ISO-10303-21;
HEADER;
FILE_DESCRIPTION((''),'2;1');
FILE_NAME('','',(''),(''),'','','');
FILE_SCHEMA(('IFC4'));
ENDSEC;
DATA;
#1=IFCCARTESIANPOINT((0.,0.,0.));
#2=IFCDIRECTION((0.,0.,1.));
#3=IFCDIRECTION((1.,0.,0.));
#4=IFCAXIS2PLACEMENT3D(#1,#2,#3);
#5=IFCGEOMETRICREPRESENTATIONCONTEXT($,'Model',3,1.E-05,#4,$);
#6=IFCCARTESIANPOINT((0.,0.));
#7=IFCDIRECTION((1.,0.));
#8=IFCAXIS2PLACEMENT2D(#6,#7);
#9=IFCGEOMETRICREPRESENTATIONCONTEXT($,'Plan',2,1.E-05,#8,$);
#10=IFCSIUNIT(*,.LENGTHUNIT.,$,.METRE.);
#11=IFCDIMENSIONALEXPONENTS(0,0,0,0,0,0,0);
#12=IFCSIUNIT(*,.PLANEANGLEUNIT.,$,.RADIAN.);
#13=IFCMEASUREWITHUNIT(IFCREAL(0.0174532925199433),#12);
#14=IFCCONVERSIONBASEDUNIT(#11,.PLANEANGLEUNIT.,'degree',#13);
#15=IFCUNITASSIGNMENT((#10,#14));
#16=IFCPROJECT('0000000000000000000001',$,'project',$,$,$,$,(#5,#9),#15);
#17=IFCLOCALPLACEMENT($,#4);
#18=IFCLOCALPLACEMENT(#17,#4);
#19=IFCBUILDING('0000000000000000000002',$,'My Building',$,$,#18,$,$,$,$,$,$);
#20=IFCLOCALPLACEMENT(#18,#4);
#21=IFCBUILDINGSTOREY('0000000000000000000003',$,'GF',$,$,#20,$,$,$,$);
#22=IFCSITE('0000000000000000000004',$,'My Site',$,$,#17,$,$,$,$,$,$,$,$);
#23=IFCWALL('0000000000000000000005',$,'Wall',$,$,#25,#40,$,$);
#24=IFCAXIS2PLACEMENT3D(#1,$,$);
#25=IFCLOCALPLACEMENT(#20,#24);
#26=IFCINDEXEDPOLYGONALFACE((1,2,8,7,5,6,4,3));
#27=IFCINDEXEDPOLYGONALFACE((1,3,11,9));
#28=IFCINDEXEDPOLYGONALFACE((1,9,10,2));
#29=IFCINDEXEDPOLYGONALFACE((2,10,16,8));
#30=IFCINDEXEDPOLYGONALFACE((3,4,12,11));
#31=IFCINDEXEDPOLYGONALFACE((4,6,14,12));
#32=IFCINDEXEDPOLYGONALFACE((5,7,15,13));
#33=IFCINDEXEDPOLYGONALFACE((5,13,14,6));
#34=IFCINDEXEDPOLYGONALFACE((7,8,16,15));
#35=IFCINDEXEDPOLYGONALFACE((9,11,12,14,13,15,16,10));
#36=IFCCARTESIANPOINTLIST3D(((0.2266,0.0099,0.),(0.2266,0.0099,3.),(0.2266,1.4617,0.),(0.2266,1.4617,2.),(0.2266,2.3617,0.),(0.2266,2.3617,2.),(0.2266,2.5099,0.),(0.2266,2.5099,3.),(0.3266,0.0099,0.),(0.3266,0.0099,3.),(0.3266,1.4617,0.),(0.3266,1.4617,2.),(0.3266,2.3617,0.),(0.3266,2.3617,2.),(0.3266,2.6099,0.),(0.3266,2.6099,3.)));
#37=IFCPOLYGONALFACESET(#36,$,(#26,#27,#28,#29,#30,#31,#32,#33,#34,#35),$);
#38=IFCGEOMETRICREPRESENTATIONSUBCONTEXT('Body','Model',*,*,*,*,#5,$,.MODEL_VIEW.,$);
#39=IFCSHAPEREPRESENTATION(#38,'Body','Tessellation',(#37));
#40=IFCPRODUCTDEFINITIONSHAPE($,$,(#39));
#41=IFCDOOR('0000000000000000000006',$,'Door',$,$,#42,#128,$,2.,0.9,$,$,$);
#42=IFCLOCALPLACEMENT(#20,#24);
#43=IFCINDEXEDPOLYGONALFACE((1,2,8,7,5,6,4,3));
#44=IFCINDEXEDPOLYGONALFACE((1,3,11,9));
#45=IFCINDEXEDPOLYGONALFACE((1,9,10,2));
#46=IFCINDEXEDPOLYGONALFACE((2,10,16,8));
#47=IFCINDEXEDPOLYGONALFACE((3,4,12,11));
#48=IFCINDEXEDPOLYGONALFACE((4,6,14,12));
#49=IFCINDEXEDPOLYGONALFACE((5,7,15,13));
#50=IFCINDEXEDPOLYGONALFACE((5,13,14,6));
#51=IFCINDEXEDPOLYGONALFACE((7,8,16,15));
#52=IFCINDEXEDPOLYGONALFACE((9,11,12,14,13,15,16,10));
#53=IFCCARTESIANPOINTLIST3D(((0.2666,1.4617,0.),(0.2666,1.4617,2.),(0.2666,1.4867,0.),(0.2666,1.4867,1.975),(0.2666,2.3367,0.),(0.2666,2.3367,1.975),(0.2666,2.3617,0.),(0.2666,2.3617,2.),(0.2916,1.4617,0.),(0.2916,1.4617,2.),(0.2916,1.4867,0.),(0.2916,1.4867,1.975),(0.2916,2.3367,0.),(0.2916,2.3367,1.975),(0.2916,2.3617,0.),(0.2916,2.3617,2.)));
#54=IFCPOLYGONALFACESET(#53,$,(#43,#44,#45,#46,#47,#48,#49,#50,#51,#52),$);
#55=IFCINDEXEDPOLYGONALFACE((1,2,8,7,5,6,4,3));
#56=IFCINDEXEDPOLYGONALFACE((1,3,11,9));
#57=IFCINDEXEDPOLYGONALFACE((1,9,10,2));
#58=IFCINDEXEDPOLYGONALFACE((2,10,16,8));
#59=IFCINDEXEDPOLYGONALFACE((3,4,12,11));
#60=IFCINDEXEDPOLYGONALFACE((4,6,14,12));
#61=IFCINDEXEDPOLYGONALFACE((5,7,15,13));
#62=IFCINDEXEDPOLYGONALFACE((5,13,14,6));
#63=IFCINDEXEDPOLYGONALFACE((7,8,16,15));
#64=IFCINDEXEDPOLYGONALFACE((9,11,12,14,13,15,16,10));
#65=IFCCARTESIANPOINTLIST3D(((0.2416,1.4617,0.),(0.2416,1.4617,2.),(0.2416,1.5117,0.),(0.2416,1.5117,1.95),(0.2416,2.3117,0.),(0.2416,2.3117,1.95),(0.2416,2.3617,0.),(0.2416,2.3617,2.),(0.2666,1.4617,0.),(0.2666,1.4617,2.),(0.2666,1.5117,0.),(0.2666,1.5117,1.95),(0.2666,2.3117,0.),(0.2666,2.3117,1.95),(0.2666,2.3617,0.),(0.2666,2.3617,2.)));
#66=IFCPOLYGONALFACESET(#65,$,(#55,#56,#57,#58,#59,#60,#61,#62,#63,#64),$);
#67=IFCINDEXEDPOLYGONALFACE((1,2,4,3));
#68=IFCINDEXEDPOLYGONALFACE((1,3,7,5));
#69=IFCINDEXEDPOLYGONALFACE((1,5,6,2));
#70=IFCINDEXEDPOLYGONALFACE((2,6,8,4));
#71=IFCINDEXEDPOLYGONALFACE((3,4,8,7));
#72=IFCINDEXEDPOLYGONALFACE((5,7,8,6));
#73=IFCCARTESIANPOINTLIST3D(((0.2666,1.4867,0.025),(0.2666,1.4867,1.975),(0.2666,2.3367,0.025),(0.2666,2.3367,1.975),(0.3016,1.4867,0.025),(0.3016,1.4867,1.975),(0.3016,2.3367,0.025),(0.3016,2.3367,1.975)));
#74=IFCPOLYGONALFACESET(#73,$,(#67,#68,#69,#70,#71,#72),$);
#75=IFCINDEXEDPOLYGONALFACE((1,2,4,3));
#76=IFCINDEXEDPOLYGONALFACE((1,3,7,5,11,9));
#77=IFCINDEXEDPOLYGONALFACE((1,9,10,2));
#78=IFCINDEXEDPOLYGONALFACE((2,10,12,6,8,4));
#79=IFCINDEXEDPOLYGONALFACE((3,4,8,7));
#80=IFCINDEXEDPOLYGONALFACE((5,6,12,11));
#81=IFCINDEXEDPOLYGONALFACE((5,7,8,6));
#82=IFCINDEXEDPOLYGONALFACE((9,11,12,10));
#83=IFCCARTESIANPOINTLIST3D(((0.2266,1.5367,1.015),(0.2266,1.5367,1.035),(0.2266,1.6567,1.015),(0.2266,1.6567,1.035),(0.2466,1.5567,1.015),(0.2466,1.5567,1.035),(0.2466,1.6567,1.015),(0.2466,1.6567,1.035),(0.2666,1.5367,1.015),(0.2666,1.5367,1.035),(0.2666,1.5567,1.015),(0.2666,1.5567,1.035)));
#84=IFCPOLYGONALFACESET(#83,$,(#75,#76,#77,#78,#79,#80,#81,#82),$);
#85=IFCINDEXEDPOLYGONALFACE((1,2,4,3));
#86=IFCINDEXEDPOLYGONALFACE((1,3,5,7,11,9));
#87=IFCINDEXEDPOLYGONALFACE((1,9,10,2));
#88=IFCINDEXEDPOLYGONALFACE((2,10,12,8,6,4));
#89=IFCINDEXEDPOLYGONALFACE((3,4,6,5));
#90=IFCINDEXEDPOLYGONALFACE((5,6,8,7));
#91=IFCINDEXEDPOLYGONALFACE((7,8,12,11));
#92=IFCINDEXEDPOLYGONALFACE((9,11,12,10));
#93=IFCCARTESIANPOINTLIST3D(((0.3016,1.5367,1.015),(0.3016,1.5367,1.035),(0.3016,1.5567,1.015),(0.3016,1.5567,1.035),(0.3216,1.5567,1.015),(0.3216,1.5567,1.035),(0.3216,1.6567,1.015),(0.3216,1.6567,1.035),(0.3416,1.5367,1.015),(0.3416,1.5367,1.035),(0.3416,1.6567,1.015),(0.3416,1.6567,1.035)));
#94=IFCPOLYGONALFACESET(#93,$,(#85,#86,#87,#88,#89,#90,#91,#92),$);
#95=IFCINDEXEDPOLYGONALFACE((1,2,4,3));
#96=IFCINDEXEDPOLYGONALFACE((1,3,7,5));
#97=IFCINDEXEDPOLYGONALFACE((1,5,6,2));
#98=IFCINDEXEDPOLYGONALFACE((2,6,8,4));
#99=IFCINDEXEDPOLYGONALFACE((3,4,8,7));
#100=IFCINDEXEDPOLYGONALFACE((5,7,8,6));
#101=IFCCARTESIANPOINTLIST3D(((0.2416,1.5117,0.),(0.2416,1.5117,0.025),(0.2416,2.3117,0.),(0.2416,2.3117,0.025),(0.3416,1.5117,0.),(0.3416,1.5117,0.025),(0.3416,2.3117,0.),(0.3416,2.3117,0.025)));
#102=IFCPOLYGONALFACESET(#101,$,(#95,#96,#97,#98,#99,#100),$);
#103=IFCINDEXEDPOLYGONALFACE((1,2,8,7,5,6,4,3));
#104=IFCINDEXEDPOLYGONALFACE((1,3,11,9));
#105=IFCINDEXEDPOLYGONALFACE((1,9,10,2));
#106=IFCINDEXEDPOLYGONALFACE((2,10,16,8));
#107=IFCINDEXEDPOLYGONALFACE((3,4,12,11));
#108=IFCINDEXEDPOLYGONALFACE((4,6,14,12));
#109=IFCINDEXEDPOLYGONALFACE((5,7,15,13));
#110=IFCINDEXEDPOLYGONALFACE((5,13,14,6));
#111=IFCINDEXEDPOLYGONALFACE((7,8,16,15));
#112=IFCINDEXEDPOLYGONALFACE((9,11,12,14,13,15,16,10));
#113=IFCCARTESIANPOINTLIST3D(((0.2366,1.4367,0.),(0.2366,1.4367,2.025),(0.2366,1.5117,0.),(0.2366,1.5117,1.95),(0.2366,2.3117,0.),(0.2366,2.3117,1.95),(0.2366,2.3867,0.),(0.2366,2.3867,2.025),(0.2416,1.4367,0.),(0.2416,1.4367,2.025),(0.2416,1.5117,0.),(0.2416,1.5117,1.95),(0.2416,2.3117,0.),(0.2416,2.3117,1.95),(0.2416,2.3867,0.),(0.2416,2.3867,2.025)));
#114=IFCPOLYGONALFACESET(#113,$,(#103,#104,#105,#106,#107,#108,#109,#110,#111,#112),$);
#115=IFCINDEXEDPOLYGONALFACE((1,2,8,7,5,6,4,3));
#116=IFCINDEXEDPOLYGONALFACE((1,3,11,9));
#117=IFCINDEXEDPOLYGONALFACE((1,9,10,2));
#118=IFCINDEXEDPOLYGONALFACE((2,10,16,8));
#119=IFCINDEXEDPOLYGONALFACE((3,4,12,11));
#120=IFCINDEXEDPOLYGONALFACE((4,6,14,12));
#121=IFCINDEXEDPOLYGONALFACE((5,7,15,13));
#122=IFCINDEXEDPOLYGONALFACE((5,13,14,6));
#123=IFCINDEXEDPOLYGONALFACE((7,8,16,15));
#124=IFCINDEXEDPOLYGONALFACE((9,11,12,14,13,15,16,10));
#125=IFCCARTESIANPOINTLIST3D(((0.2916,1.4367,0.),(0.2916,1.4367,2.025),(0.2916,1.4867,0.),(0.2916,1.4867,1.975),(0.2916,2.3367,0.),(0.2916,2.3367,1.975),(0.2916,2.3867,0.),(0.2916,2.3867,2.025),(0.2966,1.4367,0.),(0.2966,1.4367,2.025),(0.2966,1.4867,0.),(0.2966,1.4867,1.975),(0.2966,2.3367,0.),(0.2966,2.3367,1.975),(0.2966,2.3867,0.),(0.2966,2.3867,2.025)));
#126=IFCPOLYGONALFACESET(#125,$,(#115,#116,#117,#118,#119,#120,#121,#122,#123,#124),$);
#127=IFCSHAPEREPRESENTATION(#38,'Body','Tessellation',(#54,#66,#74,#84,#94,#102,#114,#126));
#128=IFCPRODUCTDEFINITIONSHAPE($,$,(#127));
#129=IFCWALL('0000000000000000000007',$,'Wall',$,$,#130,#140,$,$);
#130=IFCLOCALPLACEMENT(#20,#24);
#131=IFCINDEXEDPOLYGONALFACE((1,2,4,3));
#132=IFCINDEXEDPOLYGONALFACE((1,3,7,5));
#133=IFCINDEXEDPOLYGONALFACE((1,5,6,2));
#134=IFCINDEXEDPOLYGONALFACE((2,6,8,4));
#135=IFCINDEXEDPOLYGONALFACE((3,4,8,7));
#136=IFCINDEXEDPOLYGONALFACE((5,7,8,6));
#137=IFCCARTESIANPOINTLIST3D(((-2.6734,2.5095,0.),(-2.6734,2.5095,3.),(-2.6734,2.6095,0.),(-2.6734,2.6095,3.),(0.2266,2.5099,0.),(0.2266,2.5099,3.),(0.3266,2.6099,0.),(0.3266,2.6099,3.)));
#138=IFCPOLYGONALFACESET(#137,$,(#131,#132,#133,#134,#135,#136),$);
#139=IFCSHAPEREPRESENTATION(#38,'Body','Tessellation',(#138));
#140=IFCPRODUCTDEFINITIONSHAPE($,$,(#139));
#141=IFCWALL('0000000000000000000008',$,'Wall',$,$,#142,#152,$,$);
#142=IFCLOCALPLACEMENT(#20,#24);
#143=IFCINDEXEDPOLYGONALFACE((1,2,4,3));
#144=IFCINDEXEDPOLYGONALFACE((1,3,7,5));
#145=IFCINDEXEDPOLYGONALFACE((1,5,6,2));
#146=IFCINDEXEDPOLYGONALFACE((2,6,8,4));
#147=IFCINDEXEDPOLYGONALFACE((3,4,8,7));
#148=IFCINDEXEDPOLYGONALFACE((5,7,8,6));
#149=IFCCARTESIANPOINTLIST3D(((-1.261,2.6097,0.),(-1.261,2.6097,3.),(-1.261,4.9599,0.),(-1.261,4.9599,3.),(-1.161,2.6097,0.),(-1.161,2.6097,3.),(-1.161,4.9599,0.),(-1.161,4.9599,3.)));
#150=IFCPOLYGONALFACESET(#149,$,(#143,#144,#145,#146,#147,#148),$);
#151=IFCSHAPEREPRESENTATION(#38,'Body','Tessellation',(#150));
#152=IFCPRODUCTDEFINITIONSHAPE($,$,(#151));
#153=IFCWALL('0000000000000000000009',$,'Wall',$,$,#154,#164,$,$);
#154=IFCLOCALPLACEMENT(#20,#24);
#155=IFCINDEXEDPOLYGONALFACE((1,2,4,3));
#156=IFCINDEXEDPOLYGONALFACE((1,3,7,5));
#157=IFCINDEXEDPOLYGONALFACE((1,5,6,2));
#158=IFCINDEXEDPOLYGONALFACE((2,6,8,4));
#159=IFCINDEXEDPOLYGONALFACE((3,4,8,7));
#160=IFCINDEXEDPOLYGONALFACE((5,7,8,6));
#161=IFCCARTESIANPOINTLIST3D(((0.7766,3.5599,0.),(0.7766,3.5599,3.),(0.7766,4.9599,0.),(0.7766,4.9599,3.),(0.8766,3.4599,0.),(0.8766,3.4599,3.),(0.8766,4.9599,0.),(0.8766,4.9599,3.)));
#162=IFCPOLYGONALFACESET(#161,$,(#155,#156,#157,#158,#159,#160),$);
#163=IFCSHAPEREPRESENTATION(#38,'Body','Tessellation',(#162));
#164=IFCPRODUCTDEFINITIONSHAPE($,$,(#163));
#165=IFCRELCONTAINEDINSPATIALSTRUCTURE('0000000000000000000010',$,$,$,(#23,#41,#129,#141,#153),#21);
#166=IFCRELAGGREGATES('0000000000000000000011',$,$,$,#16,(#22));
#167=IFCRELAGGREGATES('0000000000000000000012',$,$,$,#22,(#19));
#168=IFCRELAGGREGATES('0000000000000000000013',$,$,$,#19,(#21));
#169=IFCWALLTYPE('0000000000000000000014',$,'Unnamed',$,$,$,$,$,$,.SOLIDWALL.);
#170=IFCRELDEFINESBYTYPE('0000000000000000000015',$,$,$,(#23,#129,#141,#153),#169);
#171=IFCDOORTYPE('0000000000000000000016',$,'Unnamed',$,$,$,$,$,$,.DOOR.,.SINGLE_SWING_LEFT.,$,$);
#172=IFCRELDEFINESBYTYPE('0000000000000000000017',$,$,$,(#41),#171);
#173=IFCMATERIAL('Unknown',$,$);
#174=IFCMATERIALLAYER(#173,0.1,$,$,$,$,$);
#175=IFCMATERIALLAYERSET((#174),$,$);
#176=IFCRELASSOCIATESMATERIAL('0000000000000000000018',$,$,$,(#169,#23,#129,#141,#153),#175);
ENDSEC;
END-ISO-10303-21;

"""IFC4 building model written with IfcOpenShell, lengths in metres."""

from ifc_helpers import new_model, entity, si_unit, converted_unit, frame, origin_with_axes, origin_2d_with_axis, place, context, subcontext, project, spatial, line, indexed_curve, outline, extrude, shape, source, transform, mapped, material, layer, layer_set, layer_usage, type_object, type_shapes, element, fill, save


model = new_model("IFC4")

# Units and contexts
model_context = context("Model", 3, precision=1e-05, world=origin_with_axes())
plan_context = context("Plan", 2, precision=1e-05, world=origin_2d_with_axis())
body_context_1 = subcontext(model_context, "Body", "Model", "MODEL_VIEW")
body_context_2 = subcontext(plan_context, "Body", "Plan", "PLAN_VIEW")
ifc_project = project(units=[si_unit("LENGTHUNIT", "METRE"), converted_unit("PLANEANGLEUNIT", "degree", entity("IfcReal", 0.0174532925199433), si_unit("PLANEANGLEUNIT", "RADIAN"), dimensions=[0, 0, 0, 0, 0, 0, 0])], contexts=[model_context, plan_context])

# Site, building, storey
site_placement = place(None, origin_with_axes())
site = spatial("IfcSite", under=ifc_project, at=site_placement, Name="My Site")
building_placement = place(site_placement, origin_with_axes())
building = spatial("IfcBuilding", under=site, at=building_placement, Name="My Building")
storey_placement = place(building_placement, origin_with_axes())
storey = spatial("IfcBuildingStorey", under=building, at=storey_placement, Name="GF")

# Shared definitions
ifc_material = material(Name="Unknown")

# Shared definitions
ifc_layer_1 = layer(ifc_material, 0.1)
ifc_layer_set_1 = layer_set([ifc_layer_1])
wall_type = type_object("IfcWallType", Name="Unnamed", PredefinedType="SOLIDWALL", material=ifc_layer_set_1)
shared_shape_1 = source(origin_with_axes(), body_context_1, "Body", "SweptSolid", [
    extrude(outline(indexed_curve([(0.0, 0.0), (0.9, 0.0), (0.9, 2.0), (0.0, 2.0)], segments=[line(1, 2, 3, 4, 1)])), frame((0.0, -0.6, 0.0), z_axis=(0.0, -1.0, 0.0), x_axis=(1.0, 0.0, 0.0)), (0.0, 0.0, -1.0), 1.2),
])
door_type = type_object("IfcDoorType", Name="Unnamed", OperationType="SINGLE_SWING_LEFT", PredefinedType="DOOR")
shared_shape_2 = source(origin_with_axes(), body_context_1, "Body", "SweptSolid", [
    extrude(outline(indexed_curve([(0.0, 0.0), (0.0, 2.0), (0.9, 2.0), (0.9, 0.0), (0.875, 0.0), (0.875, 1.975), (0.025, 1.975), (0.025, 0.0)], segments=[line(1, 2, 3, 4, 5, 6, 7, 8, 1)])), frame((0.0, 0.025, 0.0), z_axis=(0.0, -1.0, 0.0), x_axis=(1.0, 0.0, 0.0)), (0.0, 0.0, -1.0), 0.025),
    extrude(outline(indexed_curve([(0.0, 0.0), (0.0, 2.0), (0.9, 2.0), (0.9, 0.0), (0.85, 0.0), (0.85, 1.95), (0.05, 1.95), (0.05, 0.0)], segments=[line(1, 2, 3, 4, 5, 6, 7, 8, 1)])), frame((0.0, 0.0, 0.0), z_axis=(0.0, -1.0, 0.0), x_axis=(1.0, 0.0, 0.0)), (0.0, 0.0, -1.0), 0.025),
    extrude(outline(indexed_curve([(0.0, 0.0), (0.85, 0.0), (0.85, 0.035), (0.0, 0.035)], segments=[line(1, 2, 3, 4, 1)])), frame((0.025, 0.025, 0.025), z_axis=(0.0, 0.0, 1.0), x_axis=(1.0, 0.0, 0.0)), (0.0, 0.0, 1.0), 1.95),
    extrude(outline(indexed_curve([(0.0, 0.0), (0.0, -0.04), (-0.12, -0.04), (-0.12, -0.02), (-0.02, -0.02), (-0.02, 0.0)], segments=[line(1, 2, 3, 4, 5, 6, 1)])), frame((0.825, 0.025, 1.015), z_axis=(0.0, 0.0, 1.0), x_axis=(1.0, 0.0, 0.0)), (0.0, 0.0, 1.0), 0.02),
    extrude(outline(indexed_curve([(0.0, 0.0), (0.0, 0.04), (-0.12, 0.04), (-0.12, 0.02), (-0.02, 0.02), (-0.02, 0.0)], segments=[line(1, 2, 3, 4, 5, 6, 1)])), frame((0.825, 0.06, 1.015), z_axis=(0.0, 0.0, 1.0), x_axis=(1.0, 0.0, 0.0)), (0.0, 0.0, 1.0), 0.02),
    extrude(outline(indexed_curve([(0.0, 0.0), (0.8, 0.0), (0.8, 0.1), (0.0, 0.1)], segments=[line(1, 2, 3, 4, 1)])), frame((0.05, 0.0, 0.0), z_axis=(0.0, 0.0, 1.0), x_axis=(1.0, 0.0, 0.0)), (0.0, 0.0, 1.0), 0.025),
    extrude(outline(indexed_curve([(0.0, 0.0), (0.0, 2.025), (0.95, 2.025), (0.95, 0.0), (0.875, 0.0), (0.875, 1.95), (0.075, 1.95), (0.075, 0.0)], segments=[line(1, 2, 3, 4, 5, 6, 7, 8, 1)])), frame((-0.025, -0.005, 0.0), z_axis=(0.0, -1.0, 0.0), x_axis=(1.0, 0.0, 0.0)), (0.0, 0.0, -1.0), 0.005),
    extrude(outline(indexed_curve([(0.0, 0.0), (0.0, 2.025), (0.95, 2.025), (0.95, 0.0), (0.9, 0.0), (0.9, 1.975), (0.05, 1.975), (0.05, 0.0)], segments=[line(1, 2, 3, 4, 5, 6, 7, 8, 1)])), frame((-0.025, 0.05, 0.0), z_axis=(0.0, -1.0, 0.0), x_axis=(1.0, 0.0, 0.0)), (0.0, 0.0, -1.0), 0.005),
])
shared_shape_3 = source(origin_with_axes(), body_context_2, "Body", "Curve2D", [
    entity("IfcIndexedPolyCurve", entity("IfcCartesianPointList2D", [[0.0, 0.0], [0.0, 0.05], [0.025, 0.05], [0.025, 0.025], [0.05, 0.025], [0.05, 0.0]]), [entity("IfcLineIndex", [1, 2, 3, 4, 5, 6, 1])]),
    entity("IfcIndexedPolyCurve", entity("IfcCartesianPointList2D", [[0.9, 0.0], [0.9, 0.05], [0.875, 0.05], [0.875, 0.025], [0.85, 0.025], [0.85, 0.0]]), [entity("IfcLineIndex", [1, 2, 3, 4, 5, 6, 1])]),
    entity("IfcTrimmedCurve", entity("IfcEllipse", entity("IfcAxis2Placement2D", entity("IfcCartesianPoint", [0.06, 0.05]), entity("IfcDirection", [1.0, 0.0])), 0.815, 0.85), [entity("IfcCartesianPoint", [0.875, 0.05])], [entity("IfcCartesianPoint", [0.06, 0.9])], True, "CARTESIAN"),
    entity("IfcIndexedPolyCurve", entity("IfcCartesianPointList2D", [[0.025, 0.05], [0.06, 0.05], [0.06, 0.9], [0.025, 0.9]]), [entity("IfcLineIndex", [1, 2, 3, 4, 1])]),
])
type_shapes(door_type, [shared_shape_2, shared_shape_3])

# Wall, opening, door
ifc_layer_usage_1 = layer_usage(ifc_layer_set_1, "AXIS2", "POSITIVE", 0.0)
wall_1_placement = place(storey_placement, frame((0.3266, 0.0099, 0.0), z_axis=(0.0, 0.0, 1.0), x_axis=(0.0, 1.0, 0.0)))
wall_1 = element("IfcWall", 1, at=wall_1_placement, inside=storey, type_object=wall_type, material=ifc_layer_usage_1, Name="Wall", context=body_context_1, shape_type="SweptSolid", body=[
    extrude(outline(indexed_curve([(0.0, 0.0), (0.0, 0.1), (2.5, 0.1), (2.6, 0.0)], segments=[line(1, 2, 3, 4, 1)])), origin_with_axes(), (0.0, 0.0, 1.0), 3.0),
])
opening_1_placement = place(wall_1_placement, frame((1.4518, 0.0, 0.0), z_axis=(0.0, 0.0, 1.0), x_axis=(1.0, 0.0, 0.0)))
opening_1 = element("IfcOpeningElement", 2, at=opening_1_placement, cuts=wall_1, PredefinedType="OPENING", context=body_context_1, shape_type="MappedRepresentation", body=[
    mapped(shared_shape_1, transform((0.0, 0.0, 0.0), x_axis=(1.0, 0.0, 0.0), y_axis=(0.0, 1.0, 0.0), z_axis=(0.0, 0.0, 1.0), scale=1.0)),
])
door_1_placement = place(opening_1_placement, frame((0.9, 0.085, 0.0), z_axis=(0.0, 0.0, 1.0), x_axis=(-1.0, 0.0, 0.0)))
door_1 = element("IfcDoor", 3, at=door_1_placement, inside=storey, type_object=door_type, Name="Door", OverallHeight=2.0, OverallWidth=0.9, shapes=[
    shape(body_context_1, "Body", "MappedRepresentation", [mapped(shared_shape_2, transform((0.0, 0.0, 0.0), x_axis=(1.0, 0.0, 0.0), y_axis=(0.0, 1.0, 0.0), z_axis=(0.0, 0.0, 1.0), scale=1.0))]),
    shape(body_context_2, "Body", "MappedRepresentation", [mapped(shared_shape_3, transform((0.0, 0.0, 0.0), x_axis=(1.0, 0.0, 0.0), y_axis=(0.0, 1.0, 0.0), z_axis=(0.0, 0.0, 1.0), scale=1.0))]),
])
fill(opening_1, door_1)

# Walls
ifc_layer_usage_2 = layer_usage(ifc_layer_set_1, "AXIS2", "POSITIVE", 0.0)
wall_2_placement = place(storey_placement, frame((0.3266, 2.6099, 0.0), z_axis=(0.0, 0.0, 1.0), x_axis=(-1.0, -0.00012, 0.0)))
element("IfcWall", 4, at=wall_2_placement, inside=storey, type_object=wall_type, material=ifc_layer_usage_2, Name="Wall", context=body_context_1, shape_type="SweptSolid", body=[
    extrude(outline(indexed_curve([(0.0, 0.0), (0.1, 0.1), (3.0, 0.1), (3.0, 0.0)], segments=[line(1, 2, 3, 4, 1)])), origin_with_axes(), (0.0, 0.0, 1.0), 3.0),
])
ifc_layer_usage_3 = layer_usage(ifc_layer_set_1, "AXIS2", "POSITIVE", 0.0)
wall_3_placement = place(storey_placement, frame((-1.261, 4.9599, 0.0), z_axis=(0.0, 0.0, 1.0), x_axis=(0.000037, -1.0, 0.0)))
element("IfcWall", 5, at=wall_3_placement, inside=storey, type_object=wall_type, material=ifc_layer_usage_3, Name="Wall", context=body_context_1, shape_type="SweptSolid", body=[
    extrude(outline(indexed_curve([(0.0, 0.0), (0.0, 0.1), (2.3502, 0.1), (2.3502, 0.0)], segments=[line(1, 2, 3, 4, 1)])), origin_with_axes(), (0.0, 0.0, 1.0), 3.0),
])
ifc_layer_usage_4 = layer_usage(ifc_layer_set_1, "AXIS2", "POSITIVE", 0.0)
wall_4_placement = place(storey_placement, frame((0.7766, 4.9599, 0.0), z_axis=(0.0, 0.0, 1.0), x_axis=(0.0, -1.0, 0.0)))
element("IfcWall", 6, at=wall_4_placement, inside=storey, type_object=wall_type, material=ifc_layer_usage_4, Name="Wall", context=body_context_1, shape_type="SweptSolid", body=[
    extrude(outline(indexed_curve([(0.0, 0.0), (0.0, 0.1), (1.5, 0.1), (1.4, 0.0)], segments=[line(1, 2, 3, 4, 1)])), origin_with_axes(), (0.0, 0.0, 1.0), 3.0),
])

save(model, "model.ifc")
